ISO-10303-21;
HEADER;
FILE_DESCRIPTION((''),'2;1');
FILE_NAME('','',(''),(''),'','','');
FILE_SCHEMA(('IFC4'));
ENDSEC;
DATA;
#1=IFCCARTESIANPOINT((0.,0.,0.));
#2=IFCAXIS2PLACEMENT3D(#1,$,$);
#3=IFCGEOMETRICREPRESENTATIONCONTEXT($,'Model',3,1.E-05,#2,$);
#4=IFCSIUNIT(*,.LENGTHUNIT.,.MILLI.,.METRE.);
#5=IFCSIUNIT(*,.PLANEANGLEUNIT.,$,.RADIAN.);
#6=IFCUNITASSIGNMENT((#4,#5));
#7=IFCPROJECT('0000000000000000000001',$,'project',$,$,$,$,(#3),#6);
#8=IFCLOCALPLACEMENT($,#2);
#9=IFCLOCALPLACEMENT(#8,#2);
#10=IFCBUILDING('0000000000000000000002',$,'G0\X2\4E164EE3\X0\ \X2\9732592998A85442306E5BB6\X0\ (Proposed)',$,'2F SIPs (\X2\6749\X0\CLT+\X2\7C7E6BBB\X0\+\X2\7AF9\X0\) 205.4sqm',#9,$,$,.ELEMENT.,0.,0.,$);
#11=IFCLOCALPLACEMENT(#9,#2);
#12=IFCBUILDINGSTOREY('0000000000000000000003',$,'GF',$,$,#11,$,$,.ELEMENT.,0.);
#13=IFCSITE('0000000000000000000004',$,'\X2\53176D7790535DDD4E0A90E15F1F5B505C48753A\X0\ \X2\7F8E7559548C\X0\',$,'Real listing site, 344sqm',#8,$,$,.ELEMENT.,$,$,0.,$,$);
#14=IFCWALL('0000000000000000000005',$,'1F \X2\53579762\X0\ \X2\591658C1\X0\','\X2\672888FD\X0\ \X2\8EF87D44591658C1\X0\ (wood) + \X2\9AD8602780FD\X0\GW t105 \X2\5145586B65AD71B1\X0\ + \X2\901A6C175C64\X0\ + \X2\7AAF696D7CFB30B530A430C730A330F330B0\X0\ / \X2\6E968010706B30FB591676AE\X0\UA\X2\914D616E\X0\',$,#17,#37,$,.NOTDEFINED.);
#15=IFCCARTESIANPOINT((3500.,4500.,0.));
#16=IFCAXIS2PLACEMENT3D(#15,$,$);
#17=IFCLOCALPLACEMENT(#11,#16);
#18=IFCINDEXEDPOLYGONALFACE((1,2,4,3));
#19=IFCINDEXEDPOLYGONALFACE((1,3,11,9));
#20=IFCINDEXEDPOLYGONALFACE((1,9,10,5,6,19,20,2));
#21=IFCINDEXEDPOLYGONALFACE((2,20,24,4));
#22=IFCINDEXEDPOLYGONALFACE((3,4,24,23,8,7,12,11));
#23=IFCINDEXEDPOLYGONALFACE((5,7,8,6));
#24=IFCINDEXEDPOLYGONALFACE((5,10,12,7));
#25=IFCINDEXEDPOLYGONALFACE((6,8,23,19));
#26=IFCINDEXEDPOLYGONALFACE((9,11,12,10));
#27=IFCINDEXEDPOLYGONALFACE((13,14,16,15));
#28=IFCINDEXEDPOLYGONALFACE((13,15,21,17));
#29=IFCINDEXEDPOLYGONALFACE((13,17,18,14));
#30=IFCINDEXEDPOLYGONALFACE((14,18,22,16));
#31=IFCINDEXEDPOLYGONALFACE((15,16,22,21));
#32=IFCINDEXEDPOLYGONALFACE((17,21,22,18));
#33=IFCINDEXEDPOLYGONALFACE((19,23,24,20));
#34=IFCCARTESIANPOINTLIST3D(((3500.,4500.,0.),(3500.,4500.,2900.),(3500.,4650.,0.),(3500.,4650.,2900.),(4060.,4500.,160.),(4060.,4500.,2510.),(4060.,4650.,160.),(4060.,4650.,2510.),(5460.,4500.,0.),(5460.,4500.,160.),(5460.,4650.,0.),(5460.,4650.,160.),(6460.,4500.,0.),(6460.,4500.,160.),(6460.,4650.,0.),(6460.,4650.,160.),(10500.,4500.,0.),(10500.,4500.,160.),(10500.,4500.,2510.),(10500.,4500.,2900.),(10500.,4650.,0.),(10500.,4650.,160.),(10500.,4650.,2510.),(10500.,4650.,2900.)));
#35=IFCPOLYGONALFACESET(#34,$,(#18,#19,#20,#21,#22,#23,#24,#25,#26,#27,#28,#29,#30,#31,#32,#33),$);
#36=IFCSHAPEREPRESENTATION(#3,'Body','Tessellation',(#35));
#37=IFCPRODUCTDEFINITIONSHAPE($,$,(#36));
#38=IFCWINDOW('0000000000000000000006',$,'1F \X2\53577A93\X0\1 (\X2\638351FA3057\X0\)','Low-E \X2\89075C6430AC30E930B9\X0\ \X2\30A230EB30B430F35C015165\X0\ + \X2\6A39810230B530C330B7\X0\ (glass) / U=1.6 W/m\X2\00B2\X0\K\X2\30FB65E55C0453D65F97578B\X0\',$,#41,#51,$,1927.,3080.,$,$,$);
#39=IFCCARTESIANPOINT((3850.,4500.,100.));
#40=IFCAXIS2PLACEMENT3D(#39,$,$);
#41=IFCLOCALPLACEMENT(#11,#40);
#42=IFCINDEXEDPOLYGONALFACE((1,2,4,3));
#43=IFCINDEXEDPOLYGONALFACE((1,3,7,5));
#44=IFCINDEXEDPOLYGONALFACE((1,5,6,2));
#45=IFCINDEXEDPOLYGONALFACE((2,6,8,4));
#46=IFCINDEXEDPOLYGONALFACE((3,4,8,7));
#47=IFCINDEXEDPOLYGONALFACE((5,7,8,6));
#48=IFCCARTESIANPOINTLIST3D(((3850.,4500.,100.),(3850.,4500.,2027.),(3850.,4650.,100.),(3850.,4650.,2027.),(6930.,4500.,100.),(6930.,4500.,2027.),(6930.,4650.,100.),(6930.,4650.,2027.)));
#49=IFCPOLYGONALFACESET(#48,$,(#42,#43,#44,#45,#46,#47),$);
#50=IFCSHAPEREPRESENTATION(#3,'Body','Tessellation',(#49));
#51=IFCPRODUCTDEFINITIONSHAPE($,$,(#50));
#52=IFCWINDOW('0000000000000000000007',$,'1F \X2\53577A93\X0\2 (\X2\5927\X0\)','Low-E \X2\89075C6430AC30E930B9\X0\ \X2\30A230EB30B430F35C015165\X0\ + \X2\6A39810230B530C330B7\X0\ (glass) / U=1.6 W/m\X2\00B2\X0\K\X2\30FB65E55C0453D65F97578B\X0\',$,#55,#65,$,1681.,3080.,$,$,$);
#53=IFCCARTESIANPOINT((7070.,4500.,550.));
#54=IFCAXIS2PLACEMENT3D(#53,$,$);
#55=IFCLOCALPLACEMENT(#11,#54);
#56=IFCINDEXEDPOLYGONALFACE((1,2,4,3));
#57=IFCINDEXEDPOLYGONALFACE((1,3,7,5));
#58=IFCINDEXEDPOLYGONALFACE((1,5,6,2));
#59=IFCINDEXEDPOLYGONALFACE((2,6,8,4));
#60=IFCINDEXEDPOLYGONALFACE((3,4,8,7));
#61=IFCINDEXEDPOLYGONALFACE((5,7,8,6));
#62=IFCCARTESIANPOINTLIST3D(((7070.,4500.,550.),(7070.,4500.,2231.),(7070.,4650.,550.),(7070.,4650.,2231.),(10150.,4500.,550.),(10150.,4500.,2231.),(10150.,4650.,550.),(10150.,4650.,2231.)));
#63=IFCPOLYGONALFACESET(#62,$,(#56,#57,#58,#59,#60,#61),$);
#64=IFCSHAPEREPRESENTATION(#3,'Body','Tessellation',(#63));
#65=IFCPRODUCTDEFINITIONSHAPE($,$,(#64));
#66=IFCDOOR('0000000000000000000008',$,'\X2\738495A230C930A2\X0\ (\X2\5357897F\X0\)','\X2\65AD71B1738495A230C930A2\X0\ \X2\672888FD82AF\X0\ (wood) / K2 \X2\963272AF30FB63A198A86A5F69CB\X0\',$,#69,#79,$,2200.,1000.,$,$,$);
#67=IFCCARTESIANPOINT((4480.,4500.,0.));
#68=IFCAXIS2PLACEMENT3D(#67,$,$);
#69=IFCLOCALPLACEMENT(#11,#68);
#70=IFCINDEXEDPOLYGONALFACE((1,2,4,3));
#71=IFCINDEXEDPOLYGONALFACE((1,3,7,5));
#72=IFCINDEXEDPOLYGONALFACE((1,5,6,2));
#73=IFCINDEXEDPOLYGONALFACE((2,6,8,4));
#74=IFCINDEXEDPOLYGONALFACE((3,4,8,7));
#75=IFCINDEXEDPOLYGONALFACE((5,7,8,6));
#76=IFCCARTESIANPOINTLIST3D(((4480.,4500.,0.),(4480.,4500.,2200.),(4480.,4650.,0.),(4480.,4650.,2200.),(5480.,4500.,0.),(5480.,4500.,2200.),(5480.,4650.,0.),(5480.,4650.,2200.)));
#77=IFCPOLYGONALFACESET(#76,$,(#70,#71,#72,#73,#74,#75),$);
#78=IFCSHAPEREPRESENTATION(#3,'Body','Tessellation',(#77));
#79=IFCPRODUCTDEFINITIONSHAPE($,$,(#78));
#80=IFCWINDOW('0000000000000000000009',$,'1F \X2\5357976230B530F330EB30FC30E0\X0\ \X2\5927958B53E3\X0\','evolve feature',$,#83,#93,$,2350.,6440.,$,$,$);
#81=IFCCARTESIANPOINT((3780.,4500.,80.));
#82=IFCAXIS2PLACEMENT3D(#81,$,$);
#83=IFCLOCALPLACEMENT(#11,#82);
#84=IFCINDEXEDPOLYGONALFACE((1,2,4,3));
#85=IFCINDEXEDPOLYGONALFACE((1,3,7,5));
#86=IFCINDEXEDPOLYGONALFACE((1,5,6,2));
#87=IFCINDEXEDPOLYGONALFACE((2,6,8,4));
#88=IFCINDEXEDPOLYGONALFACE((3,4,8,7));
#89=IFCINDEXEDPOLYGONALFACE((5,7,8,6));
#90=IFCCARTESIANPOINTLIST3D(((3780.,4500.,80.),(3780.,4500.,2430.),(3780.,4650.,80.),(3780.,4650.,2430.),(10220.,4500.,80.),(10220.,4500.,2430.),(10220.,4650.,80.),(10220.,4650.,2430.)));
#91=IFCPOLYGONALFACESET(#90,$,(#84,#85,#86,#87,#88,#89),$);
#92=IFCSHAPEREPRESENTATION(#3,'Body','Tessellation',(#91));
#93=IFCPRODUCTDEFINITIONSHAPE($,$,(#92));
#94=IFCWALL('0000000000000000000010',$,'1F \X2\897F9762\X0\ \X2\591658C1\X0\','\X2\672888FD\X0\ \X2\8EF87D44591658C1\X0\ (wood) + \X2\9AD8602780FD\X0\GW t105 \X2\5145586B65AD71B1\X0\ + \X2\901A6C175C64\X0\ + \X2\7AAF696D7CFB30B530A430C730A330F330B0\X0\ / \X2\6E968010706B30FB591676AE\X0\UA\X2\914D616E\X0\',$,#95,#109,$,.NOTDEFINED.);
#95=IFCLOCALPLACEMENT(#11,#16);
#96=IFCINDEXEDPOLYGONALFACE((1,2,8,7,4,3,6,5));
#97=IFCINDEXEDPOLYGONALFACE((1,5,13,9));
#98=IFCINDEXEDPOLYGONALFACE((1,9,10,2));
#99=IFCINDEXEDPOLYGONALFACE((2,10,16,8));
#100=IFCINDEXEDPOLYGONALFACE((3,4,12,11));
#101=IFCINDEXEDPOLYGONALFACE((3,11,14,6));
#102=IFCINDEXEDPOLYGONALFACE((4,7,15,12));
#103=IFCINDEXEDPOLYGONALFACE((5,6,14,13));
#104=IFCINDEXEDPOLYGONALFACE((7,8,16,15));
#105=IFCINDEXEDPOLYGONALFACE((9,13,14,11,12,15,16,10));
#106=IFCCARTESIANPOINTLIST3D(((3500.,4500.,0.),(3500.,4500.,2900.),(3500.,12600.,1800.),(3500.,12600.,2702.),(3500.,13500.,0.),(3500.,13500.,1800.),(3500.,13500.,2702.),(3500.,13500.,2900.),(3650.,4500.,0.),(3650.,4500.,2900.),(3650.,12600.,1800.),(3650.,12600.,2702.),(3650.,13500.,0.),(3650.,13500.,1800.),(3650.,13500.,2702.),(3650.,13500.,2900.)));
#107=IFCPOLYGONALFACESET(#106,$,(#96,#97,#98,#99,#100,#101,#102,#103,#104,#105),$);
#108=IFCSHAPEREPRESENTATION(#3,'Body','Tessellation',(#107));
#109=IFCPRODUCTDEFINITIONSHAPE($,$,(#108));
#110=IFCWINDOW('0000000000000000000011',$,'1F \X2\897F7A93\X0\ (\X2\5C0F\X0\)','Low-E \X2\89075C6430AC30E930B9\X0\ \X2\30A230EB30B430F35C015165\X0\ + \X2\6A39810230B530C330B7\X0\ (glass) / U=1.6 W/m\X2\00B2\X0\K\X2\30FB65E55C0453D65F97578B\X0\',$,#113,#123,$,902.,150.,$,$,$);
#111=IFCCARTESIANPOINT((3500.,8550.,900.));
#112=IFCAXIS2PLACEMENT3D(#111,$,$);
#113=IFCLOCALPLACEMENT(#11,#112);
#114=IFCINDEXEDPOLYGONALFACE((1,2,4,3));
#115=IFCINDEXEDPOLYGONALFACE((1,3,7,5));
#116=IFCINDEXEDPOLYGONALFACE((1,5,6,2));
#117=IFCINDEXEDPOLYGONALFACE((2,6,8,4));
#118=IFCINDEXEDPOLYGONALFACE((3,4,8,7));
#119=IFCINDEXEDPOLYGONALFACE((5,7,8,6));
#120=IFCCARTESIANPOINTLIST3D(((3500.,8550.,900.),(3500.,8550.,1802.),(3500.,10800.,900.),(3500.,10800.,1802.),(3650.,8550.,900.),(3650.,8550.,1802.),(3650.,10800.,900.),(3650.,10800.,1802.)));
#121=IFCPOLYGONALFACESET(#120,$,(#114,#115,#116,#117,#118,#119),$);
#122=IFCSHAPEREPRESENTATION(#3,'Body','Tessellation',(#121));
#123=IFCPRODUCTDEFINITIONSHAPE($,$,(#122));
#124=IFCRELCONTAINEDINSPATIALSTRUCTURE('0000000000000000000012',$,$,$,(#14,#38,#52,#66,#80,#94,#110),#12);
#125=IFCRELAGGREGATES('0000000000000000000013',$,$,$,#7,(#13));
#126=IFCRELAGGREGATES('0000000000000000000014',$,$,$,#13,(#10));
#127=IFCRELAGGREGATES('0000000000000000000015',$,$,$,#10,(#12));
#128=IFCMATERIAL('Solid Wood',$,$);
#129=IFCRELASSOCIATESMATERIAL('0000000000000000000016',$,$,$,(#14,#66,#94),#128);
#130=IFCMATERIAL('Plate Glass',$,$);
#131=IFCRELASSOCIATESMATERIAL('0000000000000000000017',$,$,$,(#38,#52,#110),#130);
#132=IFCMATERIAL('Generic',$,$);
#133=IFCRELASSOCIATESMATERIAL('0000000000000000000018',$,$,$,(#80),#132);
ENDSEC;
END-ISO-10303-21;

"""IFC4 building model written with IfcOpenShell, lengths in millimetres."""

from ifc_helpers import new_model, si_unit, frame, frame_2d, origin, place, context, project, spatial, rectangle, extrude, material, element, fill, save


model = new_model("IFC4")

# Units and contexts
model_context = context("Model", 3, precision=1e-05, world=origin())
ifc_project = project(units=[si_unit("LENGTHUNIT", "METRE", prefix="MILLI"), si_unit("PLANEANGLEUNIT", "RADIAN")], contexts=[model_context])

# Site, building, storey
site_placement = place(None, origin())
site = spatial("IfcSite", under=ifc_project, at=site_placement, Name="北海道川上郡弟子屈町 美留和", ObjectType="Real listing site, 344sqm", CompositionType="ELEMENT", RefElevation=0.0)
building_placement = place(site_placement, origin())
building = spatial("IfcBuilding", under=site, at=building_placement, Name="G0世代 露天風呂の家 (Proposed)", ObjectType="2F SIPs (杉CLT+籾殻+竹) 205.4sqm", CompositionType="ELEMENT", ElevationOfRefHeight=0.0, ElevationOfTerrain=0.0)
storey_placement = place(building_placement, origin())
storey = spatial("IfcBuildingStorey", under=building, at=storey_placement, Name="GF", CompositionType="ELEMENT", Elevation=0.0)

# Shared definitions
ifc_material_1 = material(Name="Solid Wood")

# Wall, openings, windows, door
wall_1_placement = place(storey_placement, frame((3500.0, 4500.0, 0.0)))
wall_1 = element("IfcWall", 1, at=wall_1_placement, inside=storey, material=ifc_material_1, Name="1F 南面 外壁", Description="木製 軸組外壁 (wood) + 高性能GW t105 充填断熱 + 通気層 + 窯業系サイディング / 準耐火・外皮UA配慮", PredefinedType="NOTDEFINED", context=model_context, shape_type="SweptSolid", body=[
    extrude(rectangle(XDim=7000.0, YDim=150.0, at=frame_2d((3500.0, 75.0))), frame((3500.0, 4500.0, 0.0)), (0.0, 0.0, 1.0), 2900.0),
])
opening_1_placement = place(storey_placement, frame((3850.0, 4500.0, 100.0)))
opening_1 = element("IfcOpeningElement", 2, at=opening_1_placement, cuts=wall_1, PredefinedType="NOTDEFINED", context=model_context, shape_type="SweptSolid", body=[
    extrude(rectangle(XDim=3080.0, YDim=150.0, at=frame_2d((1540.0, 75.0))), frame((3850.0, 4500.0, 100.0)), (0.0, 0.0, 1.0), 1927.0),
])
opening_2_placement = place(storey_placement, frame((7070.0, 4500.0, 550.0)))
opening_2 = element("IfcOpeningElement", 3, at=opening_2_placement, cuts=wall_1, PredefinedType="NOTDEFINED", context=model_context, shape_type="SweptSolid", body=[
    extrude(rectangle(XDim=3080.0, YDim=150.0, at=frame_2d((1540.0, 75.0))), frame((7070.0, 4500.0, 550.0)), (0.0, 0.0, 1.0), 1681.0),
])
opening_3_placement = place(storey_placement, frame((4480.0, 4500.0, 0.0)))
opening_3 = element("IfcOpeningElement", 4, at=opening_3_placement, cuts=wall_1, PredefinedType="NOTDEFINED", context=model_context, shape_type="SweptSolid", body=[
    extrude(rectangle(XDim=1000.0, YDim=150.0, at=frame_2d((500.0, 75.0))), frame((4480.0, 4500.0, 0.0)), (0.0, 0.0, 1.0), 2200.0),
])
opening_4_placement = place(storey_placement, frame((3780.0, 4500.0, 80.0)))
opening_4 = element("IfcOpeningElement", 5, at=opening_4_placement, cuts=wall_1, PredefinedType="NOTDEFINED", context=model_context, shape_type="SweptSolid", body=[
    extrude(rectangle(XDim=6440.0, YDim=150.0, at=frame_2d((3220.0, 75.0))), frame((3780.0, 4500.0, 80.0)), (0.0, 0.0, 1.0), 2350.0),
])
ifc_material_2 = material(Name="Plate Glass")
window_1_placement = place(storey_placement, frame((3850.0, 4500.0, 100.0)))
window_1 = element("IfcWindow", 6, at=window_1_placement, inside=storey, material=ifc_material_2, Name="1F 南窓1 (掃出し)", Description="Low-E 複層ガラス アルゴン封入 + 樹脂サッシ (glass) / U=1.6 W/m²K・日射取得型", OverallHeight=1927.0, OverallWidth=3080.0, context=model_context, shape_type="SweptSolid", body=[
    extrude(rectangle(XDim=3080.0, YDim=150.0, at=frame_2d((1540.0, 75.0))), frame((3850.0, 4500.0, 100.0)), (0.0, 0.0, 1.0), 1927.0),
])
fill(opening_1, window_1)
window_2_placement = place(storey_placement, frame((7070.0, 4500.0, 550.0)))
window_2 = element("IfcWindow", 7, at=window_2_placement, inside=storey, material=ifc_material_2, Name="1F 南窓2 (大)", Description="Low-E 複層ガラス アルゴン封入 + 樹脂サッシ (glass) / U=1.6 W/m²K・日射取得型", OverallHeight=1681.0, OverallWidth=3080.0, context=model_context, shape_type="SweptSolid", body=[
    extrude(rectangle(XDim=3080.0, YDim=150.0, at=frame_2d((1540.0, 75.0))), frame((7070.0, 4500.0, 550.0)), (0.0, 0.0, 1.0), 1681.0),
])
fill(opening_2, window_2)
door_placement = place(storey_placement, frame((4480.0, 4500.0, 0.0)))
door = element("IfcDoor", 8, at=door_placement, inside=storey, material=ifc_material_1, Name="玄関ドア (南西)", Description="断熱玄関ドア 木製芯 (wood) / K2 防犯・採風機構", OverallHeight=2200.0, OverallWidth=1000.0, context=model_context, shape_type="SweptSolid", body=[
    extrude(rectangle(XDim=1000.0, YDim=150.0, at=frame_2d((500.0, 75.0))), frame((4480.0, 4500.0, 0.0)), (0.0, 0.0, 1.0), 2200.0),
])
fill(opening_3, door)
ifc_material_3 = material(Name="Generic")
window_3_placement = place(storey_placement, frame((3780.0, 4500.0, 80.0)))
window_3 = element("IfcWindow", 9, at=window_3_placement, inside=storey, material=ifc_material_3, Name="1F 南面サンルーム 大開口", Description="evolve feature", OverallHeight=2350.0, OverallWidth=6440.0, context=model_context, shape_type="SweptSolid", body=[
    extrude(rectangle(XDim=6440.0, YDim=150.0, at=frame_2d((3220.0, 75.0))), frame((3780.0, 4500.0, 80.0)), (0.0, 0.0, 1.0), 2350.0),
])
fill(opening_4, window_3)

# Wall, opening, window
wall_2_placement = place(storey_placement, frame((3500.0, 4500.0, 0.0)))
wall_2 = element("IfcWall", 10, at=wall_2_placement, inside=storey, material=ifc_material_1, Name="1F 西面 外壁", Description="木製 軸組外壁 (wood) + 高性能GW t105 充填断熱 + 通気層 + 窯業系サイディング / 準耐火・外皮UA配慮", PredefinedType="NOTDEFINED", context=model_context, shape_type="SweptSolid", body=[
    extrude(rectangle(XDim=150.0, YDim=9000.0, at=frame_2d((75.0, 4500.0))), frame((3500.0, 4500.0, 0.0)), (0.0, 0.0, 1.0), 2900.0),
])
opening_5_placement = place(storey_placement, frame((3500.0, 8550.0, 900.0)))
opening_5 = element("IfcOpeningElement", 11, at=opening_5_placement, cuts=wall_2, PredefinedType="NOTDEFINED", context=model_context, shape_type="SweptSolid", body=[
    extrude(rectangle(XDim=150.0, YDim=2250.0, at=frame_2d((75.0, 1125.0))), frame((3500.0, 8550.0, 900.0)), (0.0, 0.0, 1.0), 902.0),
])
window_4_placement = place(storey_placement, frame((3500.0, 8550.0, 900.0)))
window_4 = element("IfcWindow", 12, at=window_4_placement, inside=storey, material=ifc_material_2, Name="1F 西窓 (小)", Description="Low-E 複層ガラス アルゴン封入 + 樹脂サッシ (glass) / U=1.6 W/m²K・日射取得型", OverallHeight=902.0, OverallWidth=150.0, context=model_context, shape_type="SweptSolid", body=[
    extrude(rectangle(XDim=150.0, YDim=2250.0, at=frame_2d((75.0, 1125.0))), frame((3500.0, 8550.0, 900.0)), (0.0, 0.0, 1.0), 902.0),
])
fill(opening_5, window_4)

save(model, "model.ifc")
